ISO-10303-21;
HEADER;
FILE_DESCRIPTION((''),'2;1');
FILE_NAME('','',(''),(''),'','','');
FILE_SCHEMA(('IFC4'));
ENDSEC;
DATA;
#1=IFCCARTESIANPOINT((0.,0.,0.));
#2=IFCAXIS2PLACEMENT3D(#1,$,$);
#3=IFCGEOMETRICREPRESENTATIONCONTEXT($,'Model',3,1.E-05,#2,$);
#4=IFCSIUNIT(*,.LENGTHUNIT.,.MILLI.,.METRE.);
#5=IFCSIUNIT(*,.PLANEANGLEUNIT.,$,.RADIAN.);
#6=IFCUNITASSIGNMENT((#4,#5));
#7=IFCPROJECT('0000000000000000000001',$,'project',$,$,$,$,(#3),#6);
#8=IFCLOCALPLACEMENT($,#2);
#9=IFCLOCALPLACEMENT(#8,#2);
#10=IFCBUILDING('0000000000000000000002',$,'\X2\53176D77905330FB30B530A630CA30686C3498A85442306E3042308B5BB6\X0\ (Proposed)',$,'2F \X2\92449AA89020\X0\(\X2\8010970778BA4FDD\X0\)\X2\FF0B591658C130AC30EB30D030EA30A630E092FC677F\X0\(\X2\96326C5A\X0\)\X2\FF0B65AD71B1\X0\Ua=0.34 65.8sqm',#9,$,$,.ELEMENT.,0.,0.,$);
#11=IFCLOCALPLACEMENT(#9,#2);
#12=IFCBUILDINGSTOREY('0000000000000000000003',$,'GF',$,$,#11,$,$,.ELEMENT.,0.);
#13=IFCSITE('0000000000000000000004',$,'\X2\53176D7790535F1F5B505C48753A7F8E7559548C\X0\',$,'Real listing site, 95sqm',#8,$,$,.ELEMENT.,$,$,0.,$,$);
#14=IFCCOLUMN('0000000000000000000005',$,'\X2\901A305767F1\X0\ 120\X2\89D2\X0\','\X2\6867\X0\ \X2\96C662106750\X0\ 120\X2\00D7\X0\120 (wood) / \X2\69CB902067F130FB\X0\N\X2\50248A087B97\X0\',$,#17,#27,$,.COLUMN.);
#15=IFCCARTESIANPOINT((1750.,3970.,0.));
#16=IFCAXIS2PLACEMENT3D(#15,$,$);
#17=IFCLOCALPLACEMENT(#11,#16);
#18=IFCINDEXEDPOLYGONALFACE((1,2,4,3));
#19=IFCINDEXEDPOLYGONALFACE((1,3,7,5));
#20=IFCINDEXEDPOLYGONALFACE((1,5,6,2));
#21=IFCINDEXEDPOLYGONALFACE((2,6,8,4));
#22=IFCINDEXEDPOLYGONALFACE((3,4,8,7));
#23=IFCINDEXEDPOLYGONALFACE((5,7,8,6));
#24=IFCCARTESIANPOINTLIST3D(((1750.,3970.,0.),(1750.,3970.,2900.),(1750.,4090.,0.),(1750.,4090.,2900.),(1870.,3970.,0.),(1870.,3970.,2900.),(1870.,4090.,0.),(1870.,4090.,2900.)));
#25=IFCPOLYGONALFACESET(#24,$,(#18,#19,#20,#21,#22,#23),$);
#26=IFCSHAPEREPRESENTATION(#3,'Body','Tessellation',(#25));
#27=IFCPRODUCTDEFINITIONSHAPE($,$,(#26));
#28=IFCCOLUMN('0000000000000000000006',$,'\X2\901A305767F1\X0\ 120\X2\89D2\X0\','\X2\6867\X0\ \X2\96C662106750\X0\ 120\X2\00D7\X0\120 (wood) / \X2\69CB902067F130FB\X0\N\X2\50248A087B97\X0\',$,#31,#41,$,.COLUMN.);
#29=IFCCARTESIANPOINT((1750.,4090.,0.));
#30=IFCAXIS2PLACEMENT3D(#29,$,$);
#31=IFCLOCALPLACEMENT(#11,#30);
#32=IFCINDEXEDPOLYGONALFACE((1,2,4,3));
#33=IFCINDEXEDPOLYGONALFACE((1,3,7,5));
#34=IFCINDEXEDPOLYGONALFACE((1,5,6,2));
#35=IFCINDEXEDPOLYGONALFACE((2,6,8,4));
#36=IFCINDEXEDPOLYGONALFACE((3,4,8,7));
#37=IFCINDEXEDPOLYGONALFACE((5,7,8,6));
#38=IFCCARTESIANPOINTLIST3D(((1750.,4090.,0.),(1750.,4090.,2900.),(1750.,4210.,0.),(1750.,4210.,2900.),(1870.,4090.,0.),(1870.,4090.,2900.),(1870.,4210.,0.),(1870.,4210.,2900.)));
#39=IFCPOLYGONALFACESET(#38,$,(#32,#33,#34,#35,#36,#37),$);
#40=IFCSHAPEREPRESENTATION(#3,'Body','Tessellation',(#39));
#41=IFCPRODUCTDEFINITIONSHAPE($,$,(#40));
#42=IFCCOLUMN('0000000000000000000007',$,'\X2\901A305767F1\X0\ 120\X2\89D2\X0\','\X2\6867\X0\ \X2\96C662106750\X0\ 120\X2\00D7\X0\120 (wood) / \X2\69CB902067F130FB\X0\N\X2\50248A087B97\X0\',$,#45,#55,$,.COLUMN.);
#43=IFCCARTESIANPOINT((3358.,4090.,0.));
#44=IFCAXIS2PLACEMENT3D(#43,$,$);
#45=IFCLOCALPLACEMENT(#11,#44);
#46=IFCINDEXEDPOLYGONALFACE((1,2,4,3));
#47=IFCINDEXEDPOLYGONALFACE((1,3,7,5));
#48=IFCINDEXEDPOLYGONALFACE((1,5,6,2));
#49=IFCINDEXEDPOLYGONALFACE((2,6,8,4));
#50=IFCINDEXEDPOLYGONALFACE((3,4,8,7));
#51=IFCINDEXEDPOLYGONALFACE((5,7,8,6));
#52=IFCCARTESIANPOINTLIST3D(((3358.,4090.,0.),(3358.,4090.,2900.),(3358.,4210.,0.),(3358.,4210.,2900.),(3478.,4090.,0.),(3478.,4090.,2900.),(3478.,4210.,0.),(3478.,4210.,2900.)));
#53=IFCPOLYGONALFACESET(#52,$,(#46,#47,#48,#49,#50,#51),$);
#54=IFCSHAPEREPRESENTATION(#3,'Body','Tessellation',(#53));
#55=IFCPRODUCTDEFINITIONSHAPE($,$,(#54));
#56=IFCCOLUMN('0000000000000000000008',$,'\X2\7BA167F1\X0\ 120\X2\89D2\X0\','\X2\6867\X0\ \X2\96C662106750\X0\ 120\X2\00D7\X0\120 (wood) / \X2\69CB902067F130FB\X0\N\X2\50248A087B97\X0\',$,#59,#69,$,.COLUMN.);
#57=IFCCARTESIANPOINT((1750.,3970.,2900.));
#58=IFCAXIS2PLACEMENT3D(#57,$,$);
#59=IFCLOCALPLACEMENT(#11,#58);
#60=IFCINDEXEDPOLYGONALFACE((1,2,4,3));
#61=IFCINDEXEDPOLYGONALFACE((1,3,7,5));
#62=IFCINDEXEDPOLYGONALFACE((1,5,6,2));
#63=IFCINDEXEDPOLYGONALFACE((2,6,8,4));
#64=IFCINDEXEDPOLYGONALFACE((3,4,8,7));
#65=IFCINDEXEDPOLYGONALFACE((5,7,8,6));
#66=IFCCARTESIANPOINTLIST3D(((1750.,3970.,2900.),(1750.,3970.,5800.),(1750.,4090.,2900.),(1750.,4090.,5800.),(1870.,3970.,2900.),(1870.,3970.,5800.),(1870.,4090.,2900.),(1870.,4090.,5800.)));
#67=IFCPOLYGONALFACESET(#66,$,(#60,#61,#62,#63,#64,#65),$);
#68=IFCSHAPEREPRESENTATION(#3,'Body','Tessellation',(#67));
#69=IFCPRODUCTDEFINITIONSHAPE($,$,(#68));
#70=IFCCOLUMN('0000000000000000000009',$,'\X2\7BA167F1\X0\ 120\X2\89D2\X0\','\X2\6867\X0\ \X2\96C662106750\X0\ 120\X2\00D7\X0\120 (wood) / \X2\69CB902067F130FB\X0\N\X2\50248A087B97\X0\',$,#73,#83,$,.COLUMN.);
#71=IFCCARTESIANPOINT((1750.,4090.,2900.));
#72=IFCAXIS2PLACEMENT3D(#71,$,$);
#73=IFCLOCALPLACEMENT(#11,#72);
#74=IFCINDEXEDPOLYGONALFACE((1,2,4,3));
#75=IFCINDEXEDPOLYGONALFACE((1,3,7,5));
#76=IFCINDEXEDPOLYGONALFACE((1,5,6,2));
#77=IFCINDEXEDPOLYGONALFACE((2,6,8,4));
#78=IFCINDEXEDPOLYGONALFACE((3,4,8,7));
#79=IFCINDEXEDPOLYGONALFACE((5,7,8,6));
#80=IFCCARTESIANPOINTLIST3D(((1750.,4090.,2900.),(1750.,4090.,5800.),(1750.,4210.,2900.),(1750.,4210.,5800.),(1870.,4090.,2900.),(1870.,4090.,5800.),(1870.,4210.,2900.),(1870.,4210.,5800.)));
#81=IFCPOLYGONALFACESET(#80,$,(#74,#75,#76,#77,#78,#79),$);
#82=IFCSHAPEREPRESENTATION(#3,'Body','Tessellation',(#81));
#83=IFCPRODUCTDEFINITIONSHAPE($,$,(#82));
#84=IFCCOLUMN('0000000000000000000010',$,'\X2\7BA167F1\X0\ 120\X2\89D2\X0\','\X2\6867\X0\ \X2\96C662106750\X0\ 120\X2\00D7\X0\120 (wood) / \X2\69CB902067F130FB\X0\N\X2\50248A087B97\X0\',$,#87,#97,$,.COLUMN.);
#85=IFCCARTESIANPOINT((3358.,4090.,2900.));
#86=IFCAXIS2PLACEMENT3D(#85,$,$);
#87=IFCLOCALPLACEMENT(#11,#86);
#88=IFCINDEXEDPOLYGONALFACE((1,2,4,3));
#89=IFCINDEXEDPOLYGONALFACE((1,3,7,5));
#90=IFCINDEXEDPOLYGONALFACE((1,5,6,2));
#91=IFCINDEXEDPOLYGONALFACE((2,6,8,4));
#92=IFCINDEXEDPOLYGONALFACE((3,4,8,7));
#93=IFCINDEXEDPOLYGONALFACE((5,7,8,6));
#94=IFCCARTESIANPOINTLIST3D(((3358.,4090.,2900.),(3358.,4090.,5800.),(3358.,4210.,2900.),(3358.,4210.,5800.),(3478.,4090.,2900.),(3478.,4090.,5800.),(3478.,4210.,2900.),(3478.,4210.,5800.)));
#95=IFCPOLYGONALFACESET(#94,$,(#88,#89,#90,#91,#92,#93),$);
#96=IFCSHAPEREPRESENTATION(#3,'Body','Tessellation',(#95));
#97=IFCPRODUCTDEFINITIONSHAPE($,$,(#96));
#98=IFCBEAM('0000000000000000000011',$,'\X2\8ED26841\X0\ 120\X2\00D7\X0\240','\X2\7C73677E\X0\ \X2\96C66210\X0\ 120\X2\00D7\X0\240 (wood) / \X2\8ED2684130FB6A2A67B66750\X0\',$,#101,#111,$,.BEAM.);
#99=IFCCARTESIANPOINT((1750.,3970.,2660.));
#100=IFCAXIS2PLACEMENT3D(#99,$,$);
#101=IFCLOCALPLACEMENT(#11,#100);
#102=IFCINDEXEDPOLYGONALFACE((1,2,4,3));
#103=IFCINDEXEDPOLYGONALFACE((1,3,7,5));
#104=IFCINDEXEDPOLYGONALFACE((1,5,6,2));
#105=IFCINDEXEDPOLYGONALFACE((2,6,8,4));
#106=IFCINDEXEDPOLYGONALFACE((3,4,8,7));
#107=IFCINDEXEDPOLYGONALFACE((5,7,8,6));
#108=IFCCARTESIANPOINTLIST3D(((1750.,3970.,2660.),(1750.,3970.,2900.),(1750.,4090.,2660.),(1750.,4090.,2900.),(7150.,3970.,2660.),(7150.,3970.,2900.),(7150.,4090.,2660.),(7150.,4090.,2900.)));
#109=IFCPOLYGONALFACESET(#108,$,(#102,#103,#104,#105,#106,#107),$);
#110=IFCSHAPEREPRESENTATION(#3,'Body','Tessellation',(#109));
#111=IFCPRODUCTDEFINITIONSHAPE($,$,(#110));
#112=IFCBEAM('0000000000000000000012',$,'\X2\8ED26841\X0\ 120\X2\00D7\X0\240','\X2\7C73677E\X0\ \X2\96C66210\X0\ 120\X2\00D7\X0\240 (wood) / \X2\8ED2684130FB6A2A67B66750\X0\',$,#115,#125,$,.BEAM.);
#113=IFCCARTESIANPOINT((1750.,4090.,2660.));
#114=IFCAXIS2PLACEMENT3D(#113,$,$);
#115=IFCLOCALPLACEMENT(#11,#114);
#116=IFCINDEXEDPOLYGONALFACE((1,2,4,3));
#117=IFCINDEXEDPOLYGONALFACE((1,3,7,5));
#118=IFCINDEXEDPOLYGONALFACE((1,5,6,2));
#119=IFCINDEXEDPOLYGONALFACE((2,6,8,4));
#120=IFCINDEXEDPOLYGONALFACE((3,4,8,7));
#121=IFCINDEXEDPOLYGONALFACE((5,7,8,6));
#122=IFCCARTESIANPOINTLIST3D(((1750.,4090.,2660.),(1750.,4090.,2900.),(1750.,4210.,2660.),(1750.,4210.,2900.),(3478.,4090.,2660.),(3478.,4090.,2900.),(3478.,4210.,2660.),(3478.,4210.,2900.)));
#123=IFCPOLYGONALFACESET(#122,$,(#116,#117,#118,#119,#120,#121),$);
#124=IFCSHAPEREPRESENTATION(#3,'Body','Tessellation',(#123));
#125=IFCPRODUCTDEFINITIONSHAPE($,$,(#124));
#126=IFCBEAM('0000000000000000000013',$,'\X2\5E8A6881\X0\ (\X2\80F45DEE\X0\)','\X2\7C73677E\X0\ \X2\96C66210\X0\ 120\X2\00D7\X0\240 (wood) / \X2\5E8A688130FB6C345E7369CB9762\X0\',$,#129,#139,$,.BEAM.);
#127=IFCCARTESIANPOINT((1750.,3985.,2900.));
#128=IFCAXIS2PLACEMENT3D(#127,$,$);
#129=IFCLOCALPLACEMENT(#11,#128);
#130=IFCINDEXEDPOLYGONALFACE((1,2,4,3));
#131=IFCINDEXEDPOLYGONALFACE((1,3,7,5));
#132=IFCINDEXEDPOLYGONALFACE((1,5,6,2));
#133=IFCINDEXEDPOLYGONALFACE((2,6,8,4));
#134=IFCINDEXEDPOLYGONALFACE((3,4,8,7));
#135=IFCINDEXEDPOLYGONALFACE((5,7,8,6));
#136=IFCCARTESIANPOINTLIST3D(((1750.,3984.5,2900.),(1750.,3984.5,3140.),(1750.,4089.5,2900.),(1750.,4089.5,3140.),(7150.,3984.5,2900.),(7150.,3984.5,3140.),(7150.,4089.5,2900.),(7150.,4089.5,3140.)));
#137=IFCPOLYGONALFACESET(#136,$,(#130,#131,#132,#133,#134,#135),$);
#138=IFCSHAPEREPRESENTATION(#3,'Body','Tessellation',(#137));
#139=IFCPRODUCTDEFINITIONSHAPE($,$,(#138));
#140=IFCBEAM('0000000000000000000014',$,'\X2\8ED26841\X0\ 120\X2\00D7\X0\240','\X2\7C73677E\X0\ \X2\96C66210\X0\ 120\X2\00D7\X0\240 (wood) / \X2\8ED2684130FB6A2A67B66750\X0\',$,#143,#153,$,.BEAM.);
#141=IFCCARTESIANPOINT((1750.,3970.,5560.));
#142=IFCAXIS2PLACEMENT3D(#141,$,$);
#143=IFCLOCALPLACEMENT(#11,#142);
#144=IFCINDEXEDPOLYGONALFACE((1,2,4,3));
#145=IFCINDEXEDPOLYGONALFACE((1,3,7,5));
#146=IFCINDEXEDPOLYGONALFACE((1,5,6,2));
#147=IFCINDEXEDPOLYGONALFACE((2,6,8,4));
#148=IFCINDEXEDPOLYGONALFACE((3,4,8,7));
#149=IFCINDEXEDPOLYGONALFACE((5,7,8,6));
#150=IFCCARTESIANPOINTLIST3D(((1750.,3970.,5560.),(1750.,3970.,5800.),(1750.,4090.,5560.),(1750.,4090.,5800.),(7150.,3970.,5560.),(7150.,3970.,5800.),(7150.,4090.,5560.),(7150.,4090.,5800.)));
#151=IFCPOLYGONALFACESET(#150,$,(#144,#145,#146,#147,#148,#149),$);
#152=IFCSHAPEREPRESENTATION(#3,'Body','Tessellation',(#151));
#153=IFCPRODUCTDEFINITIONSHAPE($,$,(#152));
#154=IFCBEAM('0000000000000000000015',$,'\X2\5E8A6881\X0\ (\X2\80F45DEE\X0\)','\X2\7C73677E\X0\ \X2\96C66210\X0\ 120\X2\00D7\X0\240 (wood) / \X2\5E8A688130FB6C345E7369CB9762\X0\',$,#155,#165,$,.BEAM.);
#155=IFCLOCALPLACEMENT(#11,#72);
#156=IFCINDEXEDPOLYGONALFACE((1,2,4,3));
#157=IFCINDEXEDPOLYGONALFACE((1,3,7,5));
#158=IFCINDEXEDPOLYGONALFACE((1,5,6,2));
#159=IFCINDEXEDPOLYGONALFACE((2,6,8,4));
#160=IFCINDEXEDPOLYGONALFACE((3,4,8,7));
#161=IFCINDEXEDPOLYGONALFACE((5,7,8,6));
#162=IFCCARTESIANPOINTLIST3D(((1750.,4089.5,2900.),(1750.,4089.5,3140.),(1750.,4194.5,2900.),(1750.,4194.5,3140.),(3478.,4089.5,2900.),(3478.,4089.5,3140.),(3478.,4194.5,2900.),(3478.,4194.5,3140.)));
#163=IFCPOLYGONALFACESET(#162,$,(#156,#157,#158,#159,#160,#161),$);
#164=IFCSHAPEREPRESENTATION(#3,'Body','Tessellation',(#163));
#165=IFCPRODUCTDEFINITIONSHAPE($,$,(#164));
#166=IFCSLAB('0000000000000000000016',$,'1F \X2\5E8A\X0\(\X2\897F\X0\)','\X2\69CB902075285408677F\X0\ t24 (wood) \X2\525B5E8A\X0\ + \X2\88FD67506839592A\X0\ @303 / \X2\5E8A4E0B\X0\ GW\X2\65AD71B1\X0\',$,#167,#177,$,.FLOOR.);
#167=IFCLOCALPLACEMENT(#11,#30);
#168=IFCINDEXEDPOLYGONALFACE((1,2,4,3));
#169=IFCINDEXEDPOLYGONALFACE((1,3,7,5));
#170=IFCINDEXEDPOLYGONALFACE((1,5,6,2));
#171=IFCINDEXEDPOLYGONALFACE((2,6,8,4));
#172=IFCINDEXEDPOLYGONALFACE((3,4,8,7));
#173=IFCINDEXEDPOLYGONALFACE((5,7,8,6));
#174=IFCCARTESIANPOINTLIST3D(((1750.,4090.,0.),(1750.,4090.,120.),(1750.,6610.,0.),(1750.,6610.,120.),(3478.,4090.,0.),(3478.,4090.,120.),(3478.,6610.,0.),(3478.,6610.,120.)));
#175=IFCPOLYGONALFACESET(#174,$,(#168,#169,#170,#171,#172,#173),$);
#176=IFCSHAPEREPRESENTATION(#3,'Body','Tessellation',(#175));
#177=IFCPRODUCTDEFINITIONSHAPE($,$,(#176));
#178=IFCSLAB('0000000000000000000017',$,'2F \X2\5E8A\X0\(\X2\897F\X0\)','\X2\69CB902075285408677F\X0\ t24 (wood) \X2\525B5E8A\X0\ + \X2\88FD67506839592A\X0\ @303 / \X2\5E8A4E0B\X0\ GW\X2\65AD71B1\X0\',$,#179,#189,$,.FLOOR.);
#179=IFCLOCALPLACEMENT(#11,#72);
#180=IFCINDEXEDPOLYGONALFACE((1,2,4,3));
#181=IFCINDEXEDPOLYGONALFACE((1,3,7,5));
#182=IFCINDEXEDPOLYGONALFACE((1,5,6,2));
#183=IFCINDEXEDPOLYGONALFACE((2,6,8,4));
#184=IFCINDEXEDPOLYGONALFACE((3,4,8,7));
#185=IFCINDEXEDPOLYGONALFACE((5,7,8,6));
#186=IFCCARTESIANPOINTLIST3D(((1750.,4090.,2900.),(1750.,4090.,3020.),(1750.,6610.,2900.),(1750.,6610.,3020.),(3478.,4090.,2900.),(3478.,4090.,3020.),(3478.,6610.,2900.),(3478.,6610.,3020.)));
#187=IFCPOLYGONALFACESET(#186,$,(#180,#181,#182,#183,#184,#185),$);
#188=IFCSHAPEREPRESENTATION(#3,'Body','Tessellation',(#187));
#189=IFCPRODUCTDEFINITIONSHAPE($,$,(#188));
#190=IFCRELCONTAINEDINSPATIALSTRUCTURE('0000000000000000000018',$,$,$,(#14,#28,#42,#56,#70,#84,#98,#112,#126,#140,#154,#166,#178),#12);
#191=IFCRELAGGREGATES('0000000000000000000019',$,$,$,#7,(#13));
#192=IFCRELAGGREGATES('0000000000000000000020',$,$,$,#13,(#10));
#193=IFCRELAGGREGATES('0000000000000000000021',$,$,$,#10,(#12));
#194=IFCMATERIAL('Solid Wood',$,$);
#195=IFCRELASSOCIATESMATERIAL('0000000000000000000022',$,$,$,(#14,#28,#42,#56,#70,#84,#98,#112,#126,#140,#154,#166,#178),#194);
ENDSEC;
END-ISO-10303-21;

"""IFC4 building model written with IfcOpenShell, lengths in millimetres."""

from ifc_helpers import new_model, si_unit, frame, frame_2d, origin, place, context, project, spatial, rectangle, extrude, material, element, save


model = new_model("IFC4")

# Units and contexts
model_context = context("Model", 3, precision=1e-05, world=origin())
ifc_project = project(units=[si_unit("LENGTHUNIT", "METRE", prefix="MILLI"), si_unit("PLANEANGLEUNIT", "RADIAN")], contexts=[model_context])

# Site, building, storey
site_placement = place(None, origin())
site = spatial("IfcSite", under=ifc_project, at=site_placement, Name="北海道弟子屈町美留和", ObjectType="Real listing site, 95sqm", CompositionType="ELEMENT", RefElevation=0.0)
building_placement = place(site_placement, origin())
building = spatial("IfcBuilding", under=site, at=building_placement, Name="北海道・サウナと水風呂のある家 (Proposed)", ObjectType="2F 鉄骨造(耐震確保)＋外壁ガルバリウム鋼板(防汚)＋断熱Ua=0.34 65.8sqm", CompositionType="ELEMENT", ElevationOfRefHeight=0.0, ElevationOfTerrain=0.0)
storey_placement = place(building_placement, origin())
storey = spatial("IfcBuildingStorey", under=building, at=storey_placement, Name="GF", CompositionType="ELEMENT", Elevation=0.0)

# Columns
ifc_material_1 = material(Name="Solid Wood")
column_1_placement = place(storey_placement, frame((1750.0, 3970.0, 0.0)))
element("IfcColumn", 1, at=column_1_placement, inside=storey, material=ifc_material_1, Name="通し柱 120角", Description="桧 集成材 120×120 (wood) / 構造柱・N値計算", PredefinedType="COLUMN", context=model_context, shape_type="SweptSolid", body=[
    extrude(rectangle(XDim=120.0, YDim=120.0, at=frame_2d((60.0, 60.0))), frame((1750.0, 3970.0, 0.0)), (0.0, 0.0, 1.0), 2900.0),
])
column_2_placement = place(storey_placement, frame((1750.0, 4090.0, 0.0)))
element("IfcColumn", 2, at=column_2_placement, inside=storey, material=ifc_material_1, Name="通し柱 120角", Description="桧 集成材 120×120 (wood) / 構造柱・N値計算", PredefinedType="COLUMN", context=model_context, shape_type="SweptSolid", body=[
    extrude(rectangle(XDim=120.0, YDim=120.0, at=frame_2d((60.0, 60.0))), frame((1750.0, 4090.0, 0.0)), (0.0, 0.0, 1.0), 2900.0),
])
column_3_placement = place(storey_placement, frame((3358.0, 4090.0, 0.0)))
element("IfcColumn", 3, at=column_3_placement, inside=storey, material=ifc_material_1, Name="通し柱 120角", Description="桧 集成材 120×120 (wood) / 構造柱・N値計算", PredefinedType="COLUMN", context=model_context, shape_type="SweptSolid", body=[
    extrude(rectangle(XDim=120.0, YDim=120.0, at=frame_2d((60.0, 60.0))), frame((3358.0, 4090.0, 0.0)), (0.0, 0.0, 1.0), 2900.0),
])
column_4_placement = place(storey_placement, frame((1750.0, 3970.0, 2900.0)))
element("IfcColumn", 4, at=column_4_placement, inside=storey, material=ifc_material_1, Name="管柱 120角", Description="桧 集成材 120×120 (wood) / 構造柱・N値計算", PredefinedType="COLUMN", context=model_context, shape_type="SweptSolid", body=[
    extrude(rectangle(XDim=120.0, YDim=120.0, at=frame_2d((60.0, 60.0))), frame((1750.0, 3970.0, 2900.0)), (0.0, 0.0, 1.0), 2900.0),
])
column_5_placement = place(storey_placement, frame((1750.0, 4090.0, 2900.0)))
element("IfcColumn", 5, at=column_5_placement, inside=storey, material=ifc_material_1, Name="管柱 120角", Description="桧 集成材 120×120 (wood) / 構造柱・N値計算", PredefinedType="COLUMN", context=model_context, shape_type="SweptSolid", body=[
    extrude(rectangle(XDim=120.0, YDim=120.0, at=frame_2d((60.0, 60.0))), frame((1750.0, 4090.0, 2900.0)), (0.0, 0.0, 1.0), 2900.0),
])
column_6_placement = place(storey_placement, frame((3358.0, 4090.0, 2900.0)))
element("IfcColumn", 6, at=column_6_placement, inside=storey, material=ifc_material_1, Name="管柱 120角", Description="桧 集成材 120×120 (wood) / 構造柱・N値計算", PredefinedType="COLUMN", context=model_context, shape_type="SweptSolid", body=[
    extrude(rectangle(XDim=120.0, YDim=120.0, at=frame_2d((60.0, 60.0))), frame((3358.0, 4090.0, 2900.0)), (0.0, 0.0, 1.0), 2900.0),
])

# Beams
beam_1_placement = place(storey_placement, frame((1750.0, 3970.0, 2660.0)))
element("IfcBeam", 7, at=beam_1_placement, inside=storey, material=ifc_material_1, Name="軒桁 120×240", Description="米松 集成 120×240 (wood) / 軒桁・横架材", PredefinedType="BEAM", context=model_context, shape_type="SweptSolid", body=[
    extrude(rectangle(XDim=5400.0, YDim=120.0, at=frame_2d((2700.0, 60.0))), frame((1750.0, 3970.0, 2660.0)), (0.0, 0.0, 1.0), 240.0),
])
beam_2_placement = place(storey_placement, frame((1750.0, 4090.0, 2660.0)))
element("IfcBeam", 8, at=beam_2_placement, inside=storey, material=ifc_material_1, Name="軒桁 120×240", Description="米松 集成 120×240 (wood) / 軒桁・横架材", PredefinedType="BEAM", context=model_context, shape_type="SweptSolid", body=[
    extrude(rectangle(XDim=1728.0, YDim=120.0, at=frame_2d((864.0, 60.0))), frame((1750.0, 4090.0, 2660.0)), (0.0, 0.0, 1.0), 240.0),
])
beam_3_placement = place(storey_placement, frame((1750.0, 3985.0, 2900.0)))
element("IfcBeam", 9, at=beam_3_placement, inside=storey, material=ifc_material_1, Name="床梁 (胴差)", Description="米松 集成 120×240 (wood) / 床梁・水平構面", PredefinedType="BEAM", context=model_context, shape_type="SweptSolid", body=[
    extrude(rectangle(XDim=5400.0, YDim=105.0, at=frame_2d((2700.0, 52.0))), frame((1750.0, 3985.0, 2900.0)), (0.0, 0.0, 1.0), 240.0),
])
beam_4_placement = place(storey_placement, frame((1750.0, 3970.0, 5560.0)))
element("IfcBeam", 10, at=beam_4_placement, inside=storey, material=ifc_material_1, Name="軒桁 120×240", Description="米松 集成 120×240 (wood) / 軒桁・横架材", PredefinedType="BEAM", context=model_context, shape_type="SweptSolid", body=[
    extrude(rectangle(XDim=5400.0, YDim=120.0, at=frame_2d((2700.0, 60.0))), frame((1750.0, 3970.0, 5560.0)), (0.0, 0.0, 1.0), 240.0),
])
beam_5_placement = place(storey_placement, frame((1750.0, 4090.0, 2900.0)))
element("IfcBeam", 11, at=beam_5_placement, inside=storey, material=ifc_material_1, Name="床梁 (胴差)", Description="米松 集成 120×240 (wood) / 床梁・水平構面", PredefinedType="BEAM", context=model_context, shape_type="SweptSolid", body=[
    extrude(rectangle(XDim=1728.0, YDim=105.0, at=frame_2d((864.0, 52.0))), frame((1750.0, 4090.0, 2900.0)), (0.0, 0.0, 1.0), 240.0),
])

# Slabs
slab_1_placement = place(storey_placement, frame((1750.0, 4090.0, 0.0)))
element("IfcSlab", 12, at=slab_1_placement, inside=storey, material=ifc_material_1, Name="1F 床(西)", Description="構造用合板 t24 (wood) 剛床 + 製材根太 @303 / 床下 GW断熱", PredefinedType="FLOOR", context=model_context, shape_type="SweptSolid", body=[
    extrude(rectangle(XDim=1728.0, YDim=2520.0, at=frame_2d((864.0, 1260.0))), frame((1750.0, 4090.0, 0.0)), (0.0, 0.0, 1.0), 120.0),
])
slab_2_placement = place(storey_placement, frame((1750.0, 4090.0, 2900.0)))
element("IfcSlab", 13, at=slab_2_placement, inside=storey, material=ifc_material_1, Name="2F 床(西)", Description="構造用合板 t24 (wood) 剛床 + 製材根太 @303 / 床下 GW断熱", PredefinedType="FLOOR", context=model_context, shape_type="SweptSolid", body=[
    extrude(rectangle(XDim=1728.0, YDim=2520.0, at=frame_2d((864.0, 1260.0))), frame((1750.0, 4090.0, 2900.0)), (0.0, 0.0, 1.0), 120.0),
])

save(model, "model.ifc")
